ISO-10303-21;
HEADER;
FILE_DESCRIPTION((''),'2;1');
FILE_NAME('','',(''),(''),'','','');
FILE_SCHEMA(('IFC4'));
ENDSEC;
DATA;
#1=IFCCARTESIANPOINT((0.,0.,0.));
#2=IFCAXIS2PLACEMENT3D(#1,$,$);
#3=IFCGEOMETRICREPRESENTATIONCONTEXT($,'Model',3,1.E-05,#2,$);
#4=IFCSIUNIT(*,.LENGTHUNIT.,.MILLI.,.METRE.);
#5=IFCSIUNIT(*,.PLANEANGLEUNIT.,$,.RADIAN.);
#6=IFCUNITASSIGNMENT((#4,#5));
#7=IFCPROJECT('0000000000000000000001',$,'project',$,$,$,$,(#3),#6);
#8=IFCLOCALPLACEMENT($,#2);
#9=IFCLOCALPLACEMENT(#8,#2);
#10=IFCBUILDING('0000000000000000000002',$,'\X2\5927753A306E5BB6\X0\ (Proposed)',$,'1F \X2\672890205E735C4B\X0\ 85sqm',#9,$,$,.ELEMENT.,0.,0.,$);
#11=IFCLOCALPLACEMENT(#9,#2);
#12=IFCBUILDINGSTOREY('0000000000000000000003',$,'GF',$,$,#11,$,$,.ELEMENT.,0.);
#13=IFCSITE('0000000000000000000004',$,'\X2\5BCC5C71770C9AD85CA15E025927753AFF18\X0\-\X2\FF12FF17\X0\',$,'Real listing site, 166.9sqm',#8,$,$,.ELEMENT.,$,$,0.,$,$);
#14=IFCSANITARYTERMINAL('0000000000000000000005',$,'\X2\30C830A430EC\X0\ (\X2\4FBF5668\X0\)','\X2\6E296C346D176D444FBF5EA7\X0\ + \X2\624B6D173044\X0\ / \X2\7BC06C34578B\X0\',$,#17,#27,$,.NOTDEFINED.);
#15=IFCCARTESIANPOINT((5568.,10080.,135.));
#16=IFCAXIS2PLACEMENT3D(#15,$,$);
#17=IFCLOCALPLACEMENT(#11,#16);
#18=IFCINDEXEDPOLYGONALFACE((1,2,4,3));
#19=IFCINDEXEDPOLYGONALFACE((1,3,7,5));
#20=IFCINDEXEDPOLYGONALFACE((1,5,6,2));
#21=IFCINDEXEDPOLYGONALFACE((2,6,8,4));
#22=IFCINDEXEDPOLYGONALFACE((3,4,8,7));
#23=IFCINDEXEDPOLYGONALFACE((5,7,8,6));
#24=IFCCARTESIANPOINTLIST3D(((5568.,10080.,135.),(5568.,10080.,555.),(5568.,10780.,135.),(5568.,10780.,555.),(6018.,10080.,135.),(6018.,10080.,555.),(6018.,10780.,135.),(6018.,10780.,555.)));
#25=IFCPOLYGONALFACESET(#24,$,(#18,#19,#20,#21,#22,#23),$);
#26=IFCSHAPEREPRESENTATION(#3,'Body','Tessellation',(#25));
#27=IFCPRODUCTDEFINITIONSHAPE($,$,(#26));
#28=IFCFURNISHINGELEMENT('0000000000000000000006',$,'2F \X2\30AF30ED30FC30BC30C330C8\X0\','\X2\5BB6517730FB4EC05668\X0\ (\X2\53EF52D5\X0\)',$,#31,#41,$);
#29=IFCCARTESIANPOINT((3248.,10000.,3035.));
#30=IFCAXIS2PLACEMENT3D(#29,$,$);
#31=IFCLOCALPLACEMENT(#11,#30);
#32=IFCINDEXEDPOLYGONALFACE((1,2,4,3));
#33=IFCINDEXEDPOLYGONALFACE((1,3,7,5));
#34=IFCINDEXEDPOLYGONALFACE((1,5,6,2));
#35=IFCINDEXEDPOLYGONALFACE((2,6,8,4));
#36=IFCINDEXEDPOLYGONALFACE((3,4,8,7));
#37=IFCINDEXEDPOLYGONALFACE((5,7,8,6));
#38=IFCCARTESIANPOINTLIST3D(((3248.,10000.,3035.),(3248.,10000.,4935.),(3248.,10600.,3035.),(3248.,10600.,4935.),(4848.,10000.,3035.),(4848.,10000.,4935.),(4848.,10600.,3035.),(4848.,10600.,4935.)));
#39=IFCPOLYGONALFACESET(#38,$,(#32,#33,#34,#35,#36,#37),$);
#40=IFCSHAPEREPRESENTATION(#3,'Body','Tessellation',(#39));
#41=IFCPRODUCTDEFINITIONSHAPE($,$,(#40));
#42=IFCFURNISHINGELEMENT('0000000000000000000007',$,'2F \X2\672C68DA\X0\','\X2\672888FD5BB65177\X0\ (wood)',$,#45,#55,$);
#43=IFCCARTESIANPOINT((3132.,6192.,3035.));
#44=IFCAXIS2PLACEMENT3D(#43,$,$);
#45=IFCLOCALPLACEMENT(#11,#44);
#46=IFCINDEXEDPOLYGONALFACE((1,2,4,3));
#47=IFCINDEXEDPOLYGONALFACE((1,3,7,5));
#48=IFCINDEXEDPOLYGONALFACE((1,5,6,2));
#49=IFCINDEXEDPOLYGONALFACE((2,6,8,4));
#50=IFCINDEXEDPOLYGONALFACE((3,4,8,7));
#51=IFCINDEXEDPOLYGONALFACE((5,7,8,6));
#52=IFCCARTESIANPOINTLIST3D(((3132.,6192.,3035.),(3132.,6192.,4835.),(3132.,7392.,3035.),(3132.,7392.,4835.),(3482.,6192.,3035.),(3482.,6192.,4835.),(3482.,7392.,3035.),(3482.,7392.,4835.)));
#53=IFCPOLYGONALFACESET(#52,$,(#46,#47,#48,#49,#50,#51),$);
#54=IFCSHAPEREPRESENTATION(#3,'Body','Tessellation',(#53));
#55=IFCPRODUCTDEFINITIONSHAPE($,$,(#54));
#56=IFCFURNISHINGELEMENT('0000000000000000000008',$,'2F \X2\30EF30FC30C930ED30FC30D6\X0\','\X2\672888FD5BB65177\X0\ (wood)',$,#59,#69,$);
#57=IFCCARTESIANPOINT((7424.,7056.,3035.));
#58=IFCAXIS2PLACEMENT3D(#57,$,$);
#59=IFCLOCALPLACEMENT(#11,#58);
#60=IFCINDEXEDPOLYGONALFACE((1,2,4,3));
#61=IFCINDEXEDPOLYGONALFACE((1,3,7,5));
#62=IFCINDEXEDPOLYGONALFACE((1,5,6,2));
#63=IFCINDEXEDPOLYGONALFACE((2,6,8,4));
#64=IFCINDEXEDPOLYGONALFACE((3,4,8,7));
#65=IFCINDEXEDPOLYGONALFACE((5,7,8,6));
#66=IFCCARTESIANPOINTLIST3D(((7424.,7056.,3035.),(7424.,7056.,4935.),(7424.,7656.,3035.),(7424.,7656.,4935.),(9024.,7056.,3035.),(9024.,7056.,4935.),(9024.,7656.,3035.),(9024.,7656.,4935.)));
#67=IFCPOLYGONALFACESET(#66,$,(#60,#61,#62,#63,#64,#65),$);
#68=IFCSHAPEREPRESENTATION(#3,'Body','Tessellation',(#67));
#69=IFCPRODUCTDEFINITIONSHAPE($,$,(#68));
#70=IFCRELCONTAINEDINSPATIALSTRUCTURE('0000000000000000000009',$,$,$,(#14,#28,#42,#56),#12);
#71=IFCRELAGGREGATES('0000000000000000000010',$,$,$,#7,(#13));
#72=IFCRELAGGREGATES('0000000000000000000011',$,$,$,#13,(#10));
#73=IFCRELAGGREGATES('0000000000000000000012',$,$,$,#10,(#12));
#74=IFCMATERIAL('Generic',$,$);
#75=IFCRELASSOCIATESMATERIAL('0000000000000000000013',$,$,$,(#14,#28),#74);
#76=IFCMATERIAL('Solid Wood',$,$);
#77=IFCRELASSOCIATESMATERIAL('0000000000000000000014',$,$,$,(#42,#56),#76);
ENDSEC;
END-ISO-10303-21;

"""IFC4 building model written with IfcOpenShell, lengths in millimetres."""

from ifc_helpers import new_model, si_unit, frame, frame_2d, origin, place, context, project, spatial, rectangle, extrude, material, element, save


model = new_model("IFC4")

# Units and contexts
model_context = context("Model", 3, precision=1e-05, world=origin())
ifc_project = project(units=[si_unit("LENGTHUNIT", "METRE", prefix="MILLI"), si_unit("PLANEANGLEUNIT", "RADIAN")], contexts=[model_context])

# Site, building, storey
site_placement = place(None, origin())
site = spatial("IfcSite", under=ifc_project, at=site_placement, Name="富山県高岡市大町８-２７", ObjectType="Real listing site, 166.9sqm", CompositionType="ELEMENT", RefElevation=0.0)
building_placement = place(site_placement, origin())
building = spatial("IfcBuilding", under=site, at=building_placement, Name="大町の家 (Proposed)", ObjectType="1F 木造平屋 85sqm", CompositionType="ELEMENT", ElevationOfRefHeight=0.0, ElevationOfTerrain=0.0)
storey_placement = place(building_placement, origin())
storey = spatial("IfcBuildingStorey", under=building, at=storey_placement, Name="GF", CompositionType="ELEMENT", Elevation=0.0)

# Shared definitions
ifc_material_1 = material(Name="Solid Wood")

# Shared definitions
ifc_material_2 = material(Name="Generic")

# Sanitary terminal
sanitary_terminal_placement = place(storey_placement, frame((5568.0, 10080.0, 135.0)))
element("IfcSanitaryTerminal", 1, at=sanitary_terminal_placement, inside=storey, material=ifc_material_2, Name="トイレ (便器)", Description="温水洗浄便座 + 手洗い / 節水型", PredefinedType="NOTDEFINED", context=model_context, shape_type="SweptSolid", body=[
    extrude(rectangle(XDim=450.0, YDim=700.0, at=frame_2d((225.0, 350.0))), frame((5568.0, 10080.0, 135.0)), (0.0, 0.0, 1.0), 420.0),
])

# Furnishing elements
furnishing_1_placement = place(storey_placement, frame((3248.0, 10000.0, 3035.0)))
element("IfcFurnishingElement", 2, at=furnishing_1_placement, inside=storey, material=ifc_material_2, Name="2F クローゼット", Description="家具・什器 (可動)", context=model_context, shape_type="SweptSolid", body=[
    extrude(rectangle(XDim=1600.0, YDim=600.0, at=frame_2d((800.0, 300.0))), frame((3248.0, 10000.0, 3035.0)), (0.0, 0.0, 1.0), 1900.0),
])
furnishing_2_placement = place(storey_placement, frame((3132.0, 6192.0, 3035.0)))
element("IfcFurnishingElement", 3, at=furnishing_2_placement, inside=storey, material=ifc_material_1, Name="2F 本棚", Description="木製家具 (wood)", context=model_context, shape_type="SweptSolid", body=[
    extrude(rectangle(XDim=350.0, YDim=1200.0, at=frame_2d((175.0, 600.0))), frame((3132.0, 6192.0, 3035.0)), (0.0, 0.0, 1.0), 1800.0),
])
furnishing_3_placement = place(storey_placement, frame((7424.0, 7056.0, 3035.0)))
element("IfcFurnishingElement", 4, at=furnishing_3_placement, inside=storey, material=ifc_material_1, Name="2F ワードローブ", Description="木製家具 (wood)", context=model_context, shape_type="SweptSolid", body=[
    extrude(rectangle(XDim=1600.0, YDim=600.0, at=frame_2d((800.0, 300.0))), frame((7424.0, 7056.0, 3035.0)), (0.0, 0.0, 1.0), 1900.0),
])

save(model, "model.ifc")
